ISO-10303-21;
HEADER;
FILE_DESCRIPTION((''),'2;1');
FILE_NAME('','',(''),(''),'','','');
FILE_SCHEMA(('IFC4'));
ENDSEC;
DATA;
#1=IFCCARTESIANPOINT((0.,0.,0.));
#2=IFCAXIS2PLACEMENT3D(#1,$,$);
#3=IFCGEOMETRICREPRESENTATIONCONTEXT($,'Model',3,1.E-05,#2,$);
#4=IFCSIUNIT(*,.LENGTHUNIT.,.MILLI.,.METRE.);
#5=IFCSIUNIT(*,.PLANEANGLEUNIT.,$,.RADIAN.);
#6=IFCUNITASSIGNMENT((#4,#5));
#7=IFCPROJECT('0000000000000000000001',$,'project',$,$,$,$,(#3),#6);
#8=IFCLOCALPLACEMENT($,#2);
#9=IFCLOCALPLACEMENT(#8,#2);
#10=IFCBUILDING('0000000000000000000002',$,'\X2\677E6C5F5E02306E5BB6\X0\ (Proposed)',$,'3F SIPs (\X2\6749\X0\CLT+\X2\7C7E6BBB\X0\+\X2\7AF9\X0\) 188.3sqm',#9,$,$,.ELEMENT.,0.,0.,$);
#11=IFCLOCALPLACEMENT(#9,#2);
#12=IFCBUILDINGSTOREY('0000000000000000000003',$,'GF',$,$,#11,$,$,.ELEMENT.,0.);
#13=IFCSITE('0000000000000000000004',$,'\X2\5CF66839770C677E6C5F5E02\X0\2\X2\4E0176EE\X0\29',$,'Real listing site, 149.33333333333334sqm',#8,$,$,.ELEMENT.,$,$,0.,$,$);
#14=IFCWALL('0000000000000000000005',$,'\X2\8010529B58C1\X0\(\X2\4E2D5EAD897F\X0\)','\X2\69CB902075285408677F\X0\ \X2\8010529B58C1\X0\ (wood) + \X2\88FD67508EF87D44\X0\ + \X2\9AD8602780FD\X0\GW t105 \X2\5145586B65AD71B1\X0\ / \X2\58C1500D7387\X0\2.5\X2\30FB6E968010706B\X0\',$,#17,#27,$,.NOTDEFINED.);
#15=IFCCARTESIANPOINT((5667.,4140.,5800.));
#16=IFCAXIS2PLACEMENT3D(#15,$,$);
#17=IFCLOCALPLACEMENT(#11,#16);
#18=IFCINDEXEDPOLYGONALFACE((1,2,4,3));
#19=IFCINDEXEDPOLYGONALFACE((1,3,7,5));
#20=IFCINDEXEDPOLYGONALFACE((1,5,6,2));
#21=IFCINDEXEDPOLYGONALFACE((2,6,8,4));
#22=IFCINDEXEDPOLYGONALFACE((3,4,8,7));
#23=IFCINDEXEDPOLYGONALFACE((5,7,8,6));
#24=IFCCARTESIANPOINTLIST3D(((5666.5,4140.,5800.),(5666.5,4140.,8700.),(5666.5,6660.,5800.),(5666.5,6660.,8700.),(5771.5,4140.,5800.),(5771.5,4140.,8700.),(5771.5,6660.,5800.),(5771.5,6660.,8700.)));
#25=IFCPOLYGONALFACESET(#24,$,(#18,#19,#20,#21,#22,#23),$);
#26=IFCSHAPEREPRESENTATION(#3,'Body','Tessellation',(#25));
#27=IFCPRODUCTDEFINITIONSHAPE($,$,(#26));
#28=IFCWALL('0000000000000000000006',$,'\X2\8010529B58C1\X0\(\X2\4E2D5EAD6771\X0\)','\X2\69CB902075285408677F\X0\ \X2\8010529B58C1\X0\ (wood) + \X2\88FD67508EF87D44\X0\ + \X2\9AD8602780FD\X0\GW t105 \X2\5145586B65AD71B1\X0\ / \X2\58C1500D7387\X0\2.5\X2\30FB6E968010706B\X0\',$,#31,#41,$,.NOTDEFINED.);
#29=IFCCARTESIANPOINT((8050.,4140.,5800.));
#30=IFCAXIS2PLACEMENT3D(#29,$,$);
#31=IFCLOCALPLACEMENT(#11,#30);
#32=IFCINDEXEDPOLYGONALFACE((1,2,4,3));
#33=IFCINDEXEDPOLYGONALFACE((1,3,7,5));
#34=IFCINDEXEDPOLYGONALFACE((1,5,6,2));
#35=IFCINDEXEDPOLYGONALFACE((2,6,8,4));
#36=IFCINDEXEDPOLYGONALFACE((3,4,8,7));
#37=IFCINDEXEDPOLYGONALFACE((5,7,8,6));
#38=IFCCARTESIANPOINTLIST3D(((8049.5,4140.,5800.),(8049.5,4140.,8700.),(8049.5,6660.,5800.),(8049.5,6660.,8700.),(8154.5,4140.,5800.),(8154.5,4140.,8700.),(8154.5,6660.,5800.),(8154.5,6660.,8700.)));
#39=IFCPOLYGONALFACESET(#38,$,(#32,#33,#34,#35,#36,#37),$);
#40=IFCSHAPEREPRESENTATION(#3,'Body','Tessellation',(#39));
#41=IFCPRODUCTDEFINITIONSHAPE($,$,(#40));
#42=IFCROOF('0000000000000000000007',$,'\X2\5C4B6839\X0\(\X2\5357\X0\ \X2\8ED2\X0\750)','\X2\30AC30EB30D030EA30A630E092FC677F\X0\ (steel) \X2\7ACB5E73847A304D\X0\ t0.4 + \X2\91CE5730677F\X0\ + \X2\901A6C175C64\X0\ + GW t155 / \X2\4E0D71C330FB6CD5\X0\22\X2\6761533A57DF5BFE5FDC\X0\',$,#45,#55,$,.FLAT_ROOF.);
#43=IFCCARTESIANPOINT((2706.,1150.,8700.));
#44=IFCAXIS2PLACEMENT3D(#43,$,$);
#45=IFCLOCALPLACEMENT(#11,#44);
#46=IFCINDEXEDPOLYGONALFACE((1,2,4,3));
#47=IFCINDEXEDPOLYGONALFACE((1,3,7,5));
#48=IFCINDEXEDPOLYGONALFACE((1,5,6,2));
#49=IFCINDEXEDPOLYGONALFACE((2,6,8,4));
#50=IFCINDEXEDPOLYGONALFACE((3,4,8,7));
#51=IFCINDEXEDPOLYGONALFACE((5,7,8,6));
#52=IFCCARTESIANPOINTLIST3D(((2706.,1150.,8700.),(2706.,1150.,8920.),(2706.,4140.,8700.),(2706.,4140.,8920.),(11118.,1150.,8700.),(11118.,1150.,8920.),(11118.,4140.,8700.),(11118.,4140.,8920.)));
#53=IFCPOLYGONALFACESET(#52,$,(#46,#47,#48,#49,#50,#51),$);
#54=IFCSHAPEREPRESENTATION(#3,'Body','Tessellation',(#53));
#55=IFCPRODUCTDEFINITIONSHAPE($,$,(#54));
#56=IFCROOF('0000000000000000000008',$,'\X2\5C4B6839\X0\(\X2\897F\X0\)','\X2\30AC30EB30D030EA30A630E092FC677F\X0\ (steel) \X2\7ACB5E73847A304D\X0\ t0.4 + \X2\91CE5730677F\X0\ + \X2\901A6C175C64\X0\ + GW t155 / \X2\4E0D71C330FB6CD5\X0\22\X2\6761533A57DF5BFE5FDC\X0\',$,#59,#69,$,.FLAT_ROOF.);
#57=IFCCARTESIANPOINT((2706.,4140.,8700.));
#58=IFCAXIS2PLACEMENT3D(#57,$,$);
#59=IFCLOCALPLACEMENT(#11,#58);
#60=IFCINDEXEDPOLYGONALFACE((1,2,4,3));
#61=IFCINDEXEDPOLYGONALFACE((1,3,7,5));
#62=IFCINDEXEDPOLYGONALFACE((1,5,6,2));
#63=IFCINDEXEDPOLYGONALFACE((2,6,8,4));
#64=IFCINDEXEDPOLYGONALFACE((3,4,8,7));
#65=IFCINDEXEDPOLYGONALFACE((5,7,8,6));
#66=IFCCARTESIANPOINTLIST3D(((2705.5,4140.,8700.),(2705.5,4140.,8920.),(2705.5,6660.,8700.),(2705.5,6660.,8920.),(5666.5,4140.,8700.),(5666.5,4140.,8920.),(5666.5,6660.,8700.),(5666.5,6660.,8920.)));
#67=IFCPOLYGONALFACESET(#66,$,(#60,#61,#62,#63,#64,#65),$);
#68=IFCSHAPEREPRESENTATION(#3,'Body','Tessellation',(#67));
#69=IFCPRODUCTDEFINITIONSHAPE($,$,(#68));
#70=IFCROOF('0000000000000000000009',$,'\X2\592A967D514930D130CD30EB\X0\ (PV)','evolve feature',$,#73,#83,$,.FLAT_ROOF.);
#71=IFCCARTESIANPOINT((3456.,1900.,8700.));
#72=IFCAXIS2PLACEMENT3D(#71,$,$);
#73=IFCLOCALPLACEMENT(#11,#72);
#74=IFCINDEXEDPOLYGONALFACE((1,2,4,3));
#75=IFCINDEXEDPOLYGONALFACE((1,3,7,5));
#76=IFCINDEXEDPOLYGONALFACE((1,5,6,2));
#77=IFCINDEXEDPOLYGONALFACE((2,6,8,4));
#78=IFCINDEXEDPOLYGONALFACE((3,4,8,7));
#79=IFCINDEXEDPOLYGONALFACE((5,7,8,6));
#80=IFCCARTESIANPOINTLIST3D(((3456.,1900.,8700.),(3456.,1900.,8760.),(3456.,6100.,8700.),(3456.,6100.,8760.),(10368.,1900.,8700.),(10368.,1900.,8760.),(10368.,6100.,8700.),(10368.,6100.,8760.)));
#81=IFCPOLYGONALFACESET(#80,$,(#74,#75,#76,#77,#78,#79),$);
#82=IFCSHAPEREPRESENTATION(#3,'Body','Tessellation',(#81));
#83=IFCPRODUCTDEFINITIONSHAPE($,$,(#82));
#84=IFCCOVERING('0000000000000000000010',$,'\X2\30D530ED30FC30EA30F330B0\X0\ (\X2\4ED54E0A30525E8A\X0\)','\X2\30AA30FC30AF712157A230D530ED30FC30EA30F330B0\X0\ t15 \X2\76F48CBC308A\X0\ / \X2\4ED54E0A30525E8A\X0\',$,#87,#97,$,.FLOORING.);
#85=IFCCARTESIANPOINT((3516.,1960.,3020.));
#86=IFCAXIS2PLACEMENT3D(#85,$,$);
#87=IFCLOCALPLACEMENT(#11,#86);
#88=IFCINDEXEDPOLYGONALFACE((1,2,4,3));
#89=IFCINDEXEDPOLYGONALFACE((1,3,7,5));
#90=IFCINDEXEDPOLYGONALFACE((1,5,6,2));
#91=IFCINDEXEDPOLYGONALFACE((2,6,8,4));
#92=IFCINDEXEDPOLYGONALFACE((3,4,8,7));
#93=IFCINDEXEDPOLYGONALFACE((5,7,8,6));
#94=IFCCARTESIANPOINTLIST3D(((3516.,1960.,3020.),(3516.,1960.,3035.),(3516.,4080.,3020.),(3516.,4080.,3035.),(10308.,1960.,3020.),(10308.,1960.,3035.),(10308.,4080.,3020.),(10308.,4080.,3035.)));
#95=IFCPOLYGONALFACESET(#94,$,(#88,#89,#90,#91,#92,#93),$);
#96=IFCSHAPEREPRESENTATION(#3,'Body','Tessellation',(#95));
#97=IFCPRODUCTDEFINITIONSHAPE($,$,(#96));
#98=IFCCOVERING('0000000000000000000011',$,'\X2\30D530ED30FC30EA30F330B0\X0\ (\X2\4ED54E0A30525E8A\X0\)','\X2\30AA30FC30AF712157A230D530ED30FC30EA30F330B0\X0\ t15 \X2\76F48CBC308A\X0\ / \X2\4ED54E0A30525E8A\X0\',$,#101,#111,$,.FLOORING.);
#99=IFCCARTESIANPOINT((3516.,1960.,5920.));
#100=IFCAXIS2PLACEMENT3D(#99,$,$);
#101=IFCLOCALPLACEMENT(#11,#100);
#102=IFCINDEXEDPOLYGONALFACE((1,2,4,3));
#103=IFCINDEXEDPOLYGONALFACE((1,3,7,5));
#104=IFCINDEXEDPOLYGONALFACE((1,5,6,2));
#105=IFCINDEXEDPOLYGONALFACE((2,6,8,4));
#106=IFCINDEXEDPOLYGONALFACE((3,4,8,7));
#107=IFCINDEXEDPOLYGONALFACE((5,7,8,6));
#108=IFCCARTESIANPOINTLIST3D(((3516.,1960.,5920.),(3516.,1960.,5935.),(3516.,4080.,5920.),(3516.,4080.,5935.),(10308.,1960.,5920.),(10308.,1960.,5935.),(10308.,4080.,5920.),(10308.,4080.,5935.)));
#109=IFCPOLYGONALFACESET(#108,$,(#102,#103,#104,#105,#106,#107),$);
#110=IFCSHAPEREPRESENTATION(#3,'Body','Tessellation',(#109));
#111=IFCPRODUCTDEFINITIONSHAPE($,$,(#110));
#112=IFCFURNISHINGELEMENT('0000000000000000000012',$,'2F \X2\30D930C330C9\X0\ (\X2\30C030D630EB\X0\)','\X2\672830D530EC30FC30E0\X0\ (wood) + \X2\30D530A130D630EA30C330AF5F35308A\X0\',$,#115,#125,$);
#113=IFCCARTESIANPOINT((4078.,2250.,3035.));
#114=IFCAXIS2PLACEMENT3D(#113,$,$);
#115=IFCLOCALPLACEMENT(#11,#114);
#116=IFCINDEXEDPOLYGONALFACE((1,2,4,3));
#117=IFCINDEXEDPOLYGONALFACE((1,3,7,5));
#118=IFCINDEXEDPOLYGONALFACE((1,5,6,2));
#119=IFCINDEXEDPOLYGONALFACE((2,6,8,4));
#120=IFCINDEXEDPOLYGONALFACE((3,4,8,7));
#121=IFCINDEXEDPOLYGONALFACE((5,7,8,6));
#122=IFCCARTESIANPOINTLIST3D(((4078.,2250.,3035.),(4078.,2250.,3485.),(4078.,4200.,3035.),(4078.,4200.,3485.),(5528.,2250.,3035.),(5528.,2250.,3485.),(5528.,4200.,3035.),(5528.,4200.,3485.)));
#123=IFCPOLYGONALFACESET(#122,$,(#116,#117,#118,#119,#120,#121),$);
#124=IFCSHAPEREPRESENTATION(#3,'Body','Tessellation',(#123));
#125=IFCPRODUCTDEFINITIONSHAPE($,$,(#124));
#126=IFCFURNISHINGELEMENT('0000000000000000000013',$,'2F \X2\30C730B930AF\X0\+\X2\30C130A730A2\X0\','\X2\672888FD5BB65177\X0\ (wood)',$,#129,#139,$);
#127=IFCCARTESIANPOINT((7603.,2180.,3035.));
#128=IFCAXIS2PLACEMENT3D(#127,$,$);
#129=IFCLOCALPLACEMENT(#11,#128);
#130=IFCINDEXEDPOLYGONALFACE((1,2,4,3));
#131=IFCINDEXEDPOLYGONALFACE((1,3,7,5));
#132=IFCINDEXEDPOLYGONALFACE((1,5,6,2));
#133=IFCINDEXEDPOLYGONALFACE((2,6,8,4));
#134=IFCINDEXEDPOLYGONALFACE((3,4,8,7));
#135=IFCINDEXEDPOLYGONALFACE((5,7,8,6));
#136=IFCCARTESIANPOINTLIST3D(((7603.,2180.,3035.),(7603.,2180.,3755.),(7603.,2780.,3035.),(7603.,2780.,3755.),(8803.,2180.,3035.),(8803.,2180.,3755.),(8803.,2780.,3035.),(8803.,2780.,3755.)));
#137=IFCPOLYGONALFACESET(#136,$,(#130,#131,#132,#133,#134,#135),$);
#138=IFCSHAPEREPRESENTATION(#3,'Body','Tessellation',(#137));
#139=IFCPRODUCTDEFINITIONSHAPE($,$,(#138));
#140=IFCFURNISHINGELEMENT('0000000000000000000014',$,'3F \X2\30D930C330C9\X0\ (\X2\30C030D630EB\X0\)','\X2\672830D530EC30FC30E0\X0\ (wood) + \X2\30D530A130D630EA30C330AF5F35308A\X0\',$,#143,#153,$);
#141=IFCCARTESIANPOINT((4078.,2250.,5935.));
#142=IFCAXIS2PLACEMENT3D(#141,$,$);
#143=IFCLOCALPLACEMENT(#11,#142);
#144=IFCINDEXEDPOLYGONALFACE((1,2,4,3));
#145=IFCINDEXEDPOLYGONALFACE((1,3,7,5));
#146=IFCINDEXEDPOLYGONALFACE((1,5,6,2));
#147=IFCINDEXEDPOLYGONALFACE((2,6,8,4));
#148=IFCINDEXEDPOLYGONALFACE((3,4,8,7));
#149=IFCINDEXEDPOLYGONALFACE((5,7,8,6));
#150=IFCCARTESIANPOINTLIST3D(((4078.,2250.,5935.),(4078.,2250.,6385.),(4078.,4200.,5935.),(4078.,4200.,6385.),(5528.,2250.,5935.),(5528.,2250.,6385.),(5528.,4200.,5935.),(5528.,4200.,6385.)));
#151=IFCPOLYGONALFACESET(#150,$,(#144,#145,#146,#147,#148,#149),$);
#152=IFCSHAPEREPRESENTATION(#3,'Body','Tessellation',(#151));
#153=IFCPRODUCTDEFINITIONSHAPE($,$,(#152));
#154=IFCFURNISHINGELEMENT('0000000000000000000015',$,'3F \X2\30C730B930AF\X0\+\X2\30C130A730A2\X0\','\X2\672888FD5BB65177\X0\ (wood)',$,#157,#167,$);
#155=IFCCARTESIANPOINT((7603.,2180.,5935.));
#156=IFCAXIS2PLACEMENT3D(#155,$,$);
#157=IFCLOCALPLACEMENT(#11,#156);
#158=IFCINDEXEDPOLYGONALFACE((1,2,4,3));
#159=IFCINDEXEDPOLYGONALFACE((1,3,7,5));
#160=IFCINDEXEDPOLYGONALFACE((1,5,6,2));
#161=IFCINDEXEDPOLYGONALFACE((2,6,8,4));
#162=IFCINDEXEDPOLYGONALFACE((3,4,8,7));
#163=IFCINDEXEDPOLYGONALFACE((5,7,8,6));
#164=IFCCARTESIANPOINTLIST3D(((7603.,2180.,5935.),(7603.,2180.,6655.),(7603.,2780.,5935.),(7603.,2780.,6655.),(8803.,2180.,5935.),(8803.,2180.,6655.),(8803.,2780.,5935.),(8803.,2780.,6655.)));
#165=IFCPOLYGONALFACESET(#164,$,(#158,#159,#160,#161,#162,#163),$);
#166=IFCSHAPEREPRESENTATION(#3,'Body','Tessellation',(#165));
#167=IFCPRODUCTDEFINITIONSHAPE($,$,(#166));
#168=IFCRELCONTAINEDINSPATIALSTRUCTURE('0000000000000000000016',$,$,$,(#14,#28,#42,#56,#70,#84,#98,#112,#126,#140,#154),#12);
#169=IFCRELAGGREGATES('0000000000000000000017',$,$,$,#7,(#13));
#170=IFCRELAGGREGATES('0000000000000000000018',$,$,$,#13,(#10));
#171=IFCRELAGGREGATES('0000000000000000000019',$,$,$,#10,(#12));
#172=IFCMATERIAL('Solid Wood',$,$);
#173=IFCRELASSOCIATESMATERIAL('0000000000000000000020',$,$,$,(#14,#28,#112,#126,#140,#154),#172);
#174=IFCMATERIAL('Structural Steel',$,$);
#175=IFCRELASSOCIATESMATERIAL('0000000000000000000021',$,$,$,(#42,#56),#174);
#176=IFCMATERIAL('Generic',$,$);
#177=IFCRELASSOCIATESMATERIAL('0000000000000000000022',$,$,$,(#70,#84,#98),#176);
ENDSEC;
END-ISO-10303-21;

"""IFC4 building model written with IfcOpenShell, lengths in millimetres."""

from ifc_helpers import new_model, si_unit, frame, frame_2d, origin, place, context, project, spatial, rectangle, extrude, material, element, save


model = new_model("IFC4")

# Units and contexts
model_context = context("Model", 3, precision=1e-05, world=origin())
ifc_project = project(units=[si_unit("LENGTHUNIT", "METRE", prefix="MILLI"), si_unit("PLANEANGLEUNIT", "RADIAN")], contexts=[model_context])

# Site, building, storey
site_placement = place(None, origin())
site = spatial("IfcSite", under=ifc_project, at=site_placement, Name="島根県松江市2丁目29", ObjectType="Real listing site, 149.33333333333334sqm", CompositionType="ELEMENT", RefElevation=0.0)
building_placement = place(site_placement, origin())
building = spatial("IfcBuilding", under=site, at=building_placement, Name="松江市の家 (Proposed)", ObjectType="3F SIPs (杉CLT+籾殻+竹) 188.3sqm", CompositionType="ELEMENT", ElevationOfRefHeight=0.0, ElevationOfTerrain=0.0)
storey_placement = place(building_placement, origin())
storey = spatial("IfcBuildingStorey", under=building, at=storey_placement, Name="GF", CompositionType="ELEMENT", Elevation=0.0)

# Shared definitions
ifc_material_1 = material(Name="Solid Wood")

# Walls
wall_1_placement = place(storey_placement, frame((5667.0, 4140.0, 5800.0)))
element("IfcWall", 1, at=wall_1_placement, inside=storey, material=ifc_material_1, Name="耐力壁(中庭西)", Description="構造用合板 耐力壁 (wood) + 製材軸組 + 高性能GW t105 充填断熱 / 壁倍率2.5・準耐火", PredefinedType="NOTDEFINED", context=model_context, shape_type="SweptSolid", body=[
    extrude(rectangle(XDim=105.0, YDim=2520.0, at=frame_2d((52.0, 1260.0))), frame((5667.0, 4140.0, 5800.0)), (0.0, 0.0, 1.0), 2900.0),
])
wall_2_placement = place(storey_placement, frame((8050.0, 4140.0, 5800.0)))
element("IfcWall", 2, at=wall_2_placement, inside=storey, material=ifc_material_1, Name="耐力壁(中庭東)", Description="構造用合板 耐力壁 (wood) + 製材軸組 + 高性能GW t105 充填断熱 / 壁倍率2.5・準耐火", PredefinedType="NOTDEFINED", context=model_context, shape_type="SweptSolid", body=[
    extrude(rectangle(XDim=105.0, YDim=2520.0, at=frame_2d((52.0, 1260.0))), frame((8050.0, 4140.0, 5800.0)), (0.0, 0.0, 1.0), 2900.0),
])

# Roofs
ifc_material_2 = material(Name="Structural Steel")
roof_1_placement = place(storey_placement, frame((2706.0, 1150.0, 8700.0)))
element("IfcRoof", 3, at=roof_1_placement, inside=storey, material=ifc_material_2, Name="屋根(南 軒750)", Description="ガルバリウム鋼板 (steel) 立平葺き t0.4 + 野地板 + 通気層 + GW t155 / 不燃・法22条区域対応", PredefinedType="FLAT_ROOF", context=model_context, shape_type="SweptSolid", body=[
    extrude(rectangle(XDim=8412.0, YDim=2990.0, at=frame_2d((4206.0, 1495.0))), frame((2706.0, 1150.0, 8700.0)), (0.0, 0.0, 1.0), 220.0),
])
roof_2_placement = place(storey_placement, frame((2706.0, 4140.0, 8700.0)))
element("IfcRoof", 4, at=roof_2_placement, inside=storey, material=ifc_material_2, Name="屋根(西)", Description="ガルバリウム鋼板 (steel) 立平葺き t0.4 + 野地板 + 通気層 + GW t155 / 不燃・法22条区域対応", PredefinedType="FLAT_ROOF", context=model_context, shape_type="SweptSolid", body=[
    extrude(rectangle(XDim=2961.0, YDim=2520.0, at=frame_2d((1480.0, 1260.0))), frame((2706.0, 4140.0, 8700.0)), (0.0, 0.0, 1.0), 220.0),
])
ifc_material_3 = material(Name="Generic")
roof_3_placement = place(storey_placement, frame((3456.0, 1900.0, 8700.0)))
element("IfcRoof", 5, at=roof_3_placement, inside=storey, material=ifc_material_3, Name="太陽光パネル (PV)", Description="evolve feature", PredefinedType="FLAT_ROOF", context=model_context, shape_type="SweptSolid", body=[
    extrude(rectangle(XDim=6912.0, YDim=4200.0, at=frame_2d((3456.0, 2100.0))), frame((3456.0, 1900.0, 8700.0)), (0.0, 0.0, 1.0), 60.0),
])

# Coverings
covering_1_placement = place(storey_placement, frame((3516.0, 1960.0, 3020.0)))
element("IfcCovering", 6, at=covering_1_placement, inside=storey, material=ifc_material_3, Name="フローリング (仕上げ床)", Description="オーク無垢フローリング t15 直貼り / 仕上げ床", PredefinedType="FLOORING", context=model_context, shape_type="SweptSolid", body=[
    extrude(rectangle(XDim=6792.0, YDim=2120.0, at=frame_2d((3396.0, 1060.0))), frame((3516.0, 1960.0, 3020.0)), (0.0, 0.0, 1.0), 15.0),
])
covering_2_placement = place(storey_placement, frame((3516.0, 1960.0, 5920.0)))
element("IfcCovering", 7, at=covering_2_placement, inside=storey, material=ifc_material_3, Name="フローリング (仕上げ床)", Description="オーク無垢フローリング t15 直貼り / 仕上げ床", PredefinedType="FLOORING", context=model_context, shape_type="SweptSolid", body=[
    extrude(rectangle(XDim=6792.0, YDim=2120.0, at=frame_2d((3396.0, 1060.0))), frame((3516.0, 1960.0, 5920.0)), (0.0, 0.0, 1.0), 15.0),
])

# Furnishing elements
furnishing_1_placement = place(storey_placement, frame((4078.0, 2250.0, 3035.0)))
element("IfcFurnishingElement", 8, at=furnishing_1_placement, inside=storey, material=ifc_material_1, Name="2F ベッド (ダブル)", Description="木フレーム (wood) + ファブリック張り", context=model_context, shape_type="SweptSolid", body=[
    extrude(rectangle(XDim=1450.0, YDim=1950.0, at=frame_2d((725.0, 975.0))), frame((4078.0, 2250.0, 3035.0)), (0.0, 0.0, 1.0), 450.0),
])
furnishing_2_placement = place(storey_placement, frame((7603.0, 2180.0, 3035.0)))
element("IfcFurnishingElement", 9, at=furnishing_2_placement, inside=storey, material=ifc_material_1, Name="2F デスク+チェア", Description="木製家具 (wood)", context=model_context, shape_type="SweptSolid", body=[
    extrude(rectangle(XDim=1200.0, YDim=600.0, at=frame_2d((600.0, 300.0))), frame((7603.0, 2180.0, 3035.0)), (0.0, 0.0, 1.0), 720.0),
])
furnishing_3_placement = place(storey_placement, frame((4078.0, 2250.0, 5935.0)))
element("IfcFurnishingElement", 10, at=furnishing_3_placement, inside=storey, material=ifc_material_1, Name="3F ベッド (ダブル)", Description="木フレーム (wood) + ファブリック張り", context=model_context, shape_type="SweptSolid", body=[
    extrude(rectangle(XDim=1450.0, YDim=1950.0, at=frame_2d((725.0, 975.0))), frame((4078.0, 2250.0, 5935.0)), (0.0, 0.0, 1.0), 450.0),
])
furnishing_4_placement = place(storey_placement, frame((7603.0, 2180.0, 5935.0)))
element("IfcFurnishingElement", 11, at=furnishing_4_placement, inside=storey, material=ifc_material_1, Name="3F デスク+チェア", Description="木製家具 (wood)", context=model_context, shape_type="SweptSolid", body=[
    extrude(rectangle(XDim=1200.0, YDim=600.0, at=frame_2d((600.0, 300.0))), frame((7603.0, 2180.0, 5935.0)), (0.0, 0.0, 1.0), 720.0),
])

save(model, "model.ifc")
